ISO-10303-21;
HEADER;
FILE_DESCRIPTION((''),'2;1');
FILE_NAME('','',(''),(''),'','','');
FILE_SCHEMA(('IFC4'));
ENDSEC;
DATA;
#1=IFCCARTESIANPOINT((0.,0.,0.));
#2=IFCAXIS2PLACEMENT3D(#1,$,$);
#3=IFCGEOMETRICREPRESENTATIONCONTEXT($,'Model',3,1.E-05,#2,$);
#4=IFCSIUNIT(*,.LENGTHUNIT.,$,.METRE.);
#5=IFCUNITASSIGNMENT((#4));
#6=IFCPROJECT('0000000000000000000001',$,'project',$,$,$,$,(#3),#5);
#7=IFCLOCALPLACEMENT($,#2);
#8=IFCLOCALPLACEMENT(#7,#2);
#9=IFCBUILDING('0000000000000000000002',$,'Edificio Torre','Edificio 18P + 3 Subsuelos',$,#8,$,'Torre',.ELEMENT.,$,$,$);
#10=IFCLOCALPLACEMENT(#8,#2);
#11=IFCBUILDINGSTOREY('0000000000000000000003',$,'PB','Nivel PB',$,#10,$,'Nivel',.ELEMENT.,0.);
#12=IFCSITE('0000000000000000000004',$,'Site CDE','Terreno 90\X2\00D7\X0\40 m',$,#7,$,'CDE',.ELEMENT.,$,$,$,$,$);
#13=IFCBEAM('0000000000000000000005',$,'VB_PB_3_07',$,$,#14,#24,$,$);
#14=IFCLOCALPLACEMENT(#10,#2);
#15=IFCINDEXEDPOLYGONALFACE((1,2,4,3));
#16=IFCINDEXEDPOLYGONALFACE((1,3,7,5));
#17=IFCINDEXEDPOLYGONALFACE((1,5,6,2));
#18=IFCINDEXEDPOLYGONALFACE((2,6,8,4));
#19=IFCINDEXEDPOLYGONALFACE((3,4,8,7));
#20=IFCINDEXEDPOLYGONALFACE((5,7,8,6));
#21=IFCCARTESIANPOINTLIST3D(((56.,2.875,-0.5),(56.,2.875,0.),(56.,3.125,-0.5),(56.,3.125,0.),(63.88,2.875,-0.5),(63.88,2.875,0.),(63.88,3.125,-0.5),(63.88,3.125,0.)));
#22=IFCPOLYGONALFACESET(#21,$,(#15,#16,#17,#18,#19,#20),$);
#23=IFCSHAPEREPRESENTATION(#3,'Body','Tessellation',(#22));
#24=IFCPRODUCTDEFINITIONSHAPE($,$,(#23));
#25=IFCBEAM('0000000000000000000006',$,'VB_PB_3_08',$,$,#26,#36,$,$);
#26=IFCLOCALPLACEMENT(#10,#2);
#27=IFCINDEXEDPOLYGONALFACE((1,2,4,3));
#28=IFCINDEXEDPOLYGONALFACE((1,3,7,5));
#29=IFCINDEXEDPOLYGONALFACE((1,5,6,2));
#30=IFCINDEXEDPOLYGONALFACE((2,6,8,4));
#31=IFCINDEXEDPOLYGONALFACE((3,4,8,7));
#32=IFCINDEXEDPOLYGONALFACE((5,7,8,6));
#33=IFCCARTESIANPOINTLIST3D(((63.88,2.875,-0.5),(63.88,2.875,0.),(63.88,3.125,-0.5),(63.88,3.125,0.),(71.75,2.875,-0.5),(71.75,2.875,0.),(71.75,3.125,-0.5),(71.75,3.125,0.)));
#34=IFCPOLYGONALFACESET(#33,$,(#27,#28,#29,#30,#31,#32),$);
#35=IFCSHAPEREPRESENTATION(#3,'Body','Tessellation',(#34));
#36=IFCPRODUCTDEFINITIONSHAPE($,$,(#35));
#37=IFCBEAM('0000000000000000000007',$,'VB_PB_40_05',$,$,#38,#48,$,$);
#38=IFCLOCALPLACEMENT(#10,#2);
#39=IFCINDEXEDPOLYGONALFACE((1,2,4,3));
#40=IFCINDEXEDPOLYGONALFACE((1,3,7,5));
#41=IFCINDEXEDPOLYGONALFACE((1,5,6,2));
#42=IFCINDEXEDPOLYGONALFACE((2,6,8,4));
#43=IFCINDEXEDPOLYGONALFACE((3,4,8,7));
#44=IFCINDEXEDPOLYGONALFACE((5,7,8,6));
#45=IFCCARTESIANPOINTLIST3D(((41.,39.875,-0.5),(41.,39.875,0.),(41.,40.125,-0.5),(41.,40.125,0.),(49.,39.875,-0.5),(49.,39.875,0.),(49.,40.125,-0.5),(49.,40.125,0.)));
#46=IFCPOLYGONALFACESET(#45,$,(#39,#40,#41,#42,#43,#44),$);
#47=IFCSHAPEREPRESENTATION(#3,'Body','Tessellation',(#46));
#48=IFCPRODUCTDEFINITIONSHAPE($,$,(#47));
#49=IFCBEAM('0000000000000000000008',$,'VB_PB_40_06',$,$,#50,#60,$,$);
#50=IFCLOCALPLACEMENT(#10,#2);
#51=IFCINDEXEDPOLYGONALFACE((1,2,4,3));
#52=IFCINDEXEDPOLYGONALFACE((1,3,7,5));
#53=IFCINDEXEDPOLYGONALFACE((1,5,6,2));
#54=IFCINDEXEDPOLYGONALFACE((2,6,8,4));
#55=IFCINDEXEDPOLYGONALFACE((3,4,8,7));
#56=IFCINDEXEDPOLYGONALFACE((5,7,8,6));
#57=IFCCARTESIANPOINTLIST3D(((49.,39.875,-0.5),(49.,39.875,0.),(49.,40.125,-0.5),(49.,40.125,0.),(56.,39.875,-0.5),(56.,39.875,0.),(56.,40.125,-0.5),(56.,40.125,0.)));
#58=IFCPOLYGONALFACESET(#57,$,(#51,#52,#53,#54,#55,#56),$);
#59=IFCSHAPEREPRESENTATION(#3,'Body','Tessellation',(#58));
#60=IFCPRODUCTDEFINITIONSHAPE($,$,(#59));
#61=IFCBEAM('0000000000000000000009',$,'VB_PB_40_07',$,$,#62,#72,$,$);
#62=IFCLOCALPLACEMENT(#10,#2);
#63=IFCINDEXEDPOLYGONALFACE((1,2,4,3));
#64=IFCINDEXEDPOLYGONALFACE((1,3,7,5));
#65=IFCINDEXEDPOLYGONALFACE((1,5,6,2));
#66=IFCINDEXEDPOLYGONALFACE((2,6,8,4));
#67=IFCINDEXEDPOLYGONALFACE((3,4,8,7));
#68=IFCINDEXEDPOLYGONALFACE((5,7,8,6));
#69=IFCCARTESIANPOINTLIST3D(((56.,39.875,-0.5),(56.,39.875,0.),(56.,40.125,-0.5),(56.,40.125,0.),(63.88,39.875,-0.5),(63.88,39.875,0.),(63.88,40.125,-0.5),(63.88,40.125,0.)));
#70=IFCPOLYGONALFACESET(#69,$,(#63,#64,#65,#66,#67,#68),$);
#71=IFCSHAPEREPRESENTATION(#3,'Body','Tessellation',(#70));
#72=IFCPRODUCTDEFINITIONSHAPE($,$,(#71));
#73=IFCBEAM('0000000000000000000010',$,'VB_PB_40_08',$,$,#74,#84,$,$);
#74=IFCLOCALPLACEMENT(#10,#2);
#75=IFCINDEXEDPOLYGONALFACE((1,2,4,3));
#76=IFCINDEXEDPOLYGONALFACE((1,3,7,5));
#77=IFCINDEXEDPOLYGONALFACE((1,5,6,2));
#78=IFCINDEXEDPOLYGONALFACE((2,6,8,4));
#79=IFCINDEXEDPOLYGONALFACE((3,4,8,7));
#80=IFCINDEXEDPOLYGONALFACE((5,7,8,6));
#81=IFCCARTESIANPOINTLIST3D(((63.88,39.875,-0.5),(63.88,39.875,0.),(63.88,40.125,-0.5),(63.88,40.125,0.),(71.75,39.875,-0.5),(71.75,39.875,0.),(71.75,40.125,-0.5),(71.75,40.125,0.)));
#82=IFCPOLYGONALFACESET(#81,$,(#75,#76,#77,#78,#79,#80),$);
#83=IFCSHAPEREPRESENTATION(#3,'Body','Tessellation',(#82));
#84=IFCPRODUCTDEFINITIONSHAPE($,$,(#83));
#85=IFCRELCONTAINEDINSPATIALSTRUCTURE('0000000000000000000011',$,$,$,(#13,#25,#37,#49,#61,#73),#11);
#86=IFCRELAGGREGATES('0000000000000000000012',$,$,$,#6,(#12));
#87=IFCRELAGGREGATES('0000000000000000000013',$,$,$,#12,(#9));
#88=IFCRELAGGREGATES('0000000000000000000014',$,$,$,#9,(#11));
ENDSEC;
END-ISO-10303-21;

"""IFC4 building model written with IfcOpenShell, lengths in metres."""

from ifc_helpers import new_model, si_unit, frame, origin, origin_2d, place, context, project, spatial, rectangle, extrude, element, save


model = new_model("IFC4")

# Units and contexts
model_context = context("Model", 3, precision=1e-05, world=origin())
ifc_project = project(units=[si_unit("LENGTHUNIT", "METRE")], contexts=[model_context])

# Site, building, storey
site_placement = place(None, origin())
site = spatial("IfcSite", under=ifc_project, at=site_placement, Name="Site CDE", Description="Terreno 90×40 m", LongName="CDE", CompositionType="ELEMENT")
building_placement = place(site_placement, origin())
building = spatial("IfcBuilding", under=site, at=building_placement, Name="Edificio Torre", Description="Edificio 18P + 3 Subsuelos", LongName="Torre", CompositionType="ELEMENT")
storey_placement = place(building_placement, origin())
storey = spatial("IfcBuildingStorey", under=building, at=storey_placement, Name="PB", Description="Nivel PB", LongName="Nivel", CompositionType="ELEMENT", Elevation=0.0)

# Beams
beam_1_placement = place(storey_placement, frame((59.94, 3.0, -0.5)))
element("IfcBeam", 1, at=beam_1_placement, inside=storey, Name="VB_PB_3_07", context=model_context, shape_type="SweptSolid", body=[
    extrude(rectangle(XDim=7.88, YDim=0.25, at=origin_2d()), origin(), (0.0, 0.0, 1.0), 0.5),
])
beam_2_placement = place(storey_placement, frame((67.815, 3.0, -0.5)))
element("IfcBeam", 2, at=beam_2_placement, inside=storey, Name="VB_PB_3_08", context=model_context, shape_type="SweptSolid", body=[
    extrude(rectangle(XDim=7.87, YDim=0.25, at=origin_2d()), origin(), (0.0, 0.0, 1.0), 0.5),
])
beam_3_placement = place(storey_placement, frame((45.0, 40.0, -0.5)))
element("IfcBeam", 3, at=beam_3_placement, inside=storey, Name="VB_PB_40_05", context=model_context, shape_type="SweptSolid", body=[
    extrude(rectangle(XDim=8.0, YDim=0.25, at=origin_2d()), origin(), (0.0, 0.0, 1.0), 0.5),
])
beam_4_placement = place(storey_placement, frame((52.5, 40.0, -0.5)))
element("IfcBeam", 4, at=beam_4_placement, inside=storey, Name="VB_PB_40_06", context=model_context, shape_type="SweptSolid", body=[
    extrude(rectangle(XDim=7.0, YDim=0.25, at=origin_2d()), origin(), (0.0, 0.0, 1.0), 0.5),
])
beam_5_placement = place(storey_placement, frame((59.94, 40.0, -0.5)))
element("IfcBeam", 5, at=beam_5_placement, inside=storey, Name="VB_PB_40_07", context=model_context, shape_type="SweptSolid", body=[
    extrude(rectangle(XDim=7.88, YDim=0.25, at=origin_2d()), origin(), (0.0, 0.0, 1.0), 0.5),
])
beam_6_placement = place(storey_placement, frame((67.815, 40.0, -0.5)))
element("IfcBeam", 6, at=beam_6_placement, inside=storey, Name="VB_PB_40_08", context=model_context, shape_type="SweptSolid", body=[
    extrude(rectangle(XDim=7.87, YDim=0.25, at=origin_2d()), origin(), (0.0, 0.0, 1.0), 0.5),
])

save(model, "model.ifc")
